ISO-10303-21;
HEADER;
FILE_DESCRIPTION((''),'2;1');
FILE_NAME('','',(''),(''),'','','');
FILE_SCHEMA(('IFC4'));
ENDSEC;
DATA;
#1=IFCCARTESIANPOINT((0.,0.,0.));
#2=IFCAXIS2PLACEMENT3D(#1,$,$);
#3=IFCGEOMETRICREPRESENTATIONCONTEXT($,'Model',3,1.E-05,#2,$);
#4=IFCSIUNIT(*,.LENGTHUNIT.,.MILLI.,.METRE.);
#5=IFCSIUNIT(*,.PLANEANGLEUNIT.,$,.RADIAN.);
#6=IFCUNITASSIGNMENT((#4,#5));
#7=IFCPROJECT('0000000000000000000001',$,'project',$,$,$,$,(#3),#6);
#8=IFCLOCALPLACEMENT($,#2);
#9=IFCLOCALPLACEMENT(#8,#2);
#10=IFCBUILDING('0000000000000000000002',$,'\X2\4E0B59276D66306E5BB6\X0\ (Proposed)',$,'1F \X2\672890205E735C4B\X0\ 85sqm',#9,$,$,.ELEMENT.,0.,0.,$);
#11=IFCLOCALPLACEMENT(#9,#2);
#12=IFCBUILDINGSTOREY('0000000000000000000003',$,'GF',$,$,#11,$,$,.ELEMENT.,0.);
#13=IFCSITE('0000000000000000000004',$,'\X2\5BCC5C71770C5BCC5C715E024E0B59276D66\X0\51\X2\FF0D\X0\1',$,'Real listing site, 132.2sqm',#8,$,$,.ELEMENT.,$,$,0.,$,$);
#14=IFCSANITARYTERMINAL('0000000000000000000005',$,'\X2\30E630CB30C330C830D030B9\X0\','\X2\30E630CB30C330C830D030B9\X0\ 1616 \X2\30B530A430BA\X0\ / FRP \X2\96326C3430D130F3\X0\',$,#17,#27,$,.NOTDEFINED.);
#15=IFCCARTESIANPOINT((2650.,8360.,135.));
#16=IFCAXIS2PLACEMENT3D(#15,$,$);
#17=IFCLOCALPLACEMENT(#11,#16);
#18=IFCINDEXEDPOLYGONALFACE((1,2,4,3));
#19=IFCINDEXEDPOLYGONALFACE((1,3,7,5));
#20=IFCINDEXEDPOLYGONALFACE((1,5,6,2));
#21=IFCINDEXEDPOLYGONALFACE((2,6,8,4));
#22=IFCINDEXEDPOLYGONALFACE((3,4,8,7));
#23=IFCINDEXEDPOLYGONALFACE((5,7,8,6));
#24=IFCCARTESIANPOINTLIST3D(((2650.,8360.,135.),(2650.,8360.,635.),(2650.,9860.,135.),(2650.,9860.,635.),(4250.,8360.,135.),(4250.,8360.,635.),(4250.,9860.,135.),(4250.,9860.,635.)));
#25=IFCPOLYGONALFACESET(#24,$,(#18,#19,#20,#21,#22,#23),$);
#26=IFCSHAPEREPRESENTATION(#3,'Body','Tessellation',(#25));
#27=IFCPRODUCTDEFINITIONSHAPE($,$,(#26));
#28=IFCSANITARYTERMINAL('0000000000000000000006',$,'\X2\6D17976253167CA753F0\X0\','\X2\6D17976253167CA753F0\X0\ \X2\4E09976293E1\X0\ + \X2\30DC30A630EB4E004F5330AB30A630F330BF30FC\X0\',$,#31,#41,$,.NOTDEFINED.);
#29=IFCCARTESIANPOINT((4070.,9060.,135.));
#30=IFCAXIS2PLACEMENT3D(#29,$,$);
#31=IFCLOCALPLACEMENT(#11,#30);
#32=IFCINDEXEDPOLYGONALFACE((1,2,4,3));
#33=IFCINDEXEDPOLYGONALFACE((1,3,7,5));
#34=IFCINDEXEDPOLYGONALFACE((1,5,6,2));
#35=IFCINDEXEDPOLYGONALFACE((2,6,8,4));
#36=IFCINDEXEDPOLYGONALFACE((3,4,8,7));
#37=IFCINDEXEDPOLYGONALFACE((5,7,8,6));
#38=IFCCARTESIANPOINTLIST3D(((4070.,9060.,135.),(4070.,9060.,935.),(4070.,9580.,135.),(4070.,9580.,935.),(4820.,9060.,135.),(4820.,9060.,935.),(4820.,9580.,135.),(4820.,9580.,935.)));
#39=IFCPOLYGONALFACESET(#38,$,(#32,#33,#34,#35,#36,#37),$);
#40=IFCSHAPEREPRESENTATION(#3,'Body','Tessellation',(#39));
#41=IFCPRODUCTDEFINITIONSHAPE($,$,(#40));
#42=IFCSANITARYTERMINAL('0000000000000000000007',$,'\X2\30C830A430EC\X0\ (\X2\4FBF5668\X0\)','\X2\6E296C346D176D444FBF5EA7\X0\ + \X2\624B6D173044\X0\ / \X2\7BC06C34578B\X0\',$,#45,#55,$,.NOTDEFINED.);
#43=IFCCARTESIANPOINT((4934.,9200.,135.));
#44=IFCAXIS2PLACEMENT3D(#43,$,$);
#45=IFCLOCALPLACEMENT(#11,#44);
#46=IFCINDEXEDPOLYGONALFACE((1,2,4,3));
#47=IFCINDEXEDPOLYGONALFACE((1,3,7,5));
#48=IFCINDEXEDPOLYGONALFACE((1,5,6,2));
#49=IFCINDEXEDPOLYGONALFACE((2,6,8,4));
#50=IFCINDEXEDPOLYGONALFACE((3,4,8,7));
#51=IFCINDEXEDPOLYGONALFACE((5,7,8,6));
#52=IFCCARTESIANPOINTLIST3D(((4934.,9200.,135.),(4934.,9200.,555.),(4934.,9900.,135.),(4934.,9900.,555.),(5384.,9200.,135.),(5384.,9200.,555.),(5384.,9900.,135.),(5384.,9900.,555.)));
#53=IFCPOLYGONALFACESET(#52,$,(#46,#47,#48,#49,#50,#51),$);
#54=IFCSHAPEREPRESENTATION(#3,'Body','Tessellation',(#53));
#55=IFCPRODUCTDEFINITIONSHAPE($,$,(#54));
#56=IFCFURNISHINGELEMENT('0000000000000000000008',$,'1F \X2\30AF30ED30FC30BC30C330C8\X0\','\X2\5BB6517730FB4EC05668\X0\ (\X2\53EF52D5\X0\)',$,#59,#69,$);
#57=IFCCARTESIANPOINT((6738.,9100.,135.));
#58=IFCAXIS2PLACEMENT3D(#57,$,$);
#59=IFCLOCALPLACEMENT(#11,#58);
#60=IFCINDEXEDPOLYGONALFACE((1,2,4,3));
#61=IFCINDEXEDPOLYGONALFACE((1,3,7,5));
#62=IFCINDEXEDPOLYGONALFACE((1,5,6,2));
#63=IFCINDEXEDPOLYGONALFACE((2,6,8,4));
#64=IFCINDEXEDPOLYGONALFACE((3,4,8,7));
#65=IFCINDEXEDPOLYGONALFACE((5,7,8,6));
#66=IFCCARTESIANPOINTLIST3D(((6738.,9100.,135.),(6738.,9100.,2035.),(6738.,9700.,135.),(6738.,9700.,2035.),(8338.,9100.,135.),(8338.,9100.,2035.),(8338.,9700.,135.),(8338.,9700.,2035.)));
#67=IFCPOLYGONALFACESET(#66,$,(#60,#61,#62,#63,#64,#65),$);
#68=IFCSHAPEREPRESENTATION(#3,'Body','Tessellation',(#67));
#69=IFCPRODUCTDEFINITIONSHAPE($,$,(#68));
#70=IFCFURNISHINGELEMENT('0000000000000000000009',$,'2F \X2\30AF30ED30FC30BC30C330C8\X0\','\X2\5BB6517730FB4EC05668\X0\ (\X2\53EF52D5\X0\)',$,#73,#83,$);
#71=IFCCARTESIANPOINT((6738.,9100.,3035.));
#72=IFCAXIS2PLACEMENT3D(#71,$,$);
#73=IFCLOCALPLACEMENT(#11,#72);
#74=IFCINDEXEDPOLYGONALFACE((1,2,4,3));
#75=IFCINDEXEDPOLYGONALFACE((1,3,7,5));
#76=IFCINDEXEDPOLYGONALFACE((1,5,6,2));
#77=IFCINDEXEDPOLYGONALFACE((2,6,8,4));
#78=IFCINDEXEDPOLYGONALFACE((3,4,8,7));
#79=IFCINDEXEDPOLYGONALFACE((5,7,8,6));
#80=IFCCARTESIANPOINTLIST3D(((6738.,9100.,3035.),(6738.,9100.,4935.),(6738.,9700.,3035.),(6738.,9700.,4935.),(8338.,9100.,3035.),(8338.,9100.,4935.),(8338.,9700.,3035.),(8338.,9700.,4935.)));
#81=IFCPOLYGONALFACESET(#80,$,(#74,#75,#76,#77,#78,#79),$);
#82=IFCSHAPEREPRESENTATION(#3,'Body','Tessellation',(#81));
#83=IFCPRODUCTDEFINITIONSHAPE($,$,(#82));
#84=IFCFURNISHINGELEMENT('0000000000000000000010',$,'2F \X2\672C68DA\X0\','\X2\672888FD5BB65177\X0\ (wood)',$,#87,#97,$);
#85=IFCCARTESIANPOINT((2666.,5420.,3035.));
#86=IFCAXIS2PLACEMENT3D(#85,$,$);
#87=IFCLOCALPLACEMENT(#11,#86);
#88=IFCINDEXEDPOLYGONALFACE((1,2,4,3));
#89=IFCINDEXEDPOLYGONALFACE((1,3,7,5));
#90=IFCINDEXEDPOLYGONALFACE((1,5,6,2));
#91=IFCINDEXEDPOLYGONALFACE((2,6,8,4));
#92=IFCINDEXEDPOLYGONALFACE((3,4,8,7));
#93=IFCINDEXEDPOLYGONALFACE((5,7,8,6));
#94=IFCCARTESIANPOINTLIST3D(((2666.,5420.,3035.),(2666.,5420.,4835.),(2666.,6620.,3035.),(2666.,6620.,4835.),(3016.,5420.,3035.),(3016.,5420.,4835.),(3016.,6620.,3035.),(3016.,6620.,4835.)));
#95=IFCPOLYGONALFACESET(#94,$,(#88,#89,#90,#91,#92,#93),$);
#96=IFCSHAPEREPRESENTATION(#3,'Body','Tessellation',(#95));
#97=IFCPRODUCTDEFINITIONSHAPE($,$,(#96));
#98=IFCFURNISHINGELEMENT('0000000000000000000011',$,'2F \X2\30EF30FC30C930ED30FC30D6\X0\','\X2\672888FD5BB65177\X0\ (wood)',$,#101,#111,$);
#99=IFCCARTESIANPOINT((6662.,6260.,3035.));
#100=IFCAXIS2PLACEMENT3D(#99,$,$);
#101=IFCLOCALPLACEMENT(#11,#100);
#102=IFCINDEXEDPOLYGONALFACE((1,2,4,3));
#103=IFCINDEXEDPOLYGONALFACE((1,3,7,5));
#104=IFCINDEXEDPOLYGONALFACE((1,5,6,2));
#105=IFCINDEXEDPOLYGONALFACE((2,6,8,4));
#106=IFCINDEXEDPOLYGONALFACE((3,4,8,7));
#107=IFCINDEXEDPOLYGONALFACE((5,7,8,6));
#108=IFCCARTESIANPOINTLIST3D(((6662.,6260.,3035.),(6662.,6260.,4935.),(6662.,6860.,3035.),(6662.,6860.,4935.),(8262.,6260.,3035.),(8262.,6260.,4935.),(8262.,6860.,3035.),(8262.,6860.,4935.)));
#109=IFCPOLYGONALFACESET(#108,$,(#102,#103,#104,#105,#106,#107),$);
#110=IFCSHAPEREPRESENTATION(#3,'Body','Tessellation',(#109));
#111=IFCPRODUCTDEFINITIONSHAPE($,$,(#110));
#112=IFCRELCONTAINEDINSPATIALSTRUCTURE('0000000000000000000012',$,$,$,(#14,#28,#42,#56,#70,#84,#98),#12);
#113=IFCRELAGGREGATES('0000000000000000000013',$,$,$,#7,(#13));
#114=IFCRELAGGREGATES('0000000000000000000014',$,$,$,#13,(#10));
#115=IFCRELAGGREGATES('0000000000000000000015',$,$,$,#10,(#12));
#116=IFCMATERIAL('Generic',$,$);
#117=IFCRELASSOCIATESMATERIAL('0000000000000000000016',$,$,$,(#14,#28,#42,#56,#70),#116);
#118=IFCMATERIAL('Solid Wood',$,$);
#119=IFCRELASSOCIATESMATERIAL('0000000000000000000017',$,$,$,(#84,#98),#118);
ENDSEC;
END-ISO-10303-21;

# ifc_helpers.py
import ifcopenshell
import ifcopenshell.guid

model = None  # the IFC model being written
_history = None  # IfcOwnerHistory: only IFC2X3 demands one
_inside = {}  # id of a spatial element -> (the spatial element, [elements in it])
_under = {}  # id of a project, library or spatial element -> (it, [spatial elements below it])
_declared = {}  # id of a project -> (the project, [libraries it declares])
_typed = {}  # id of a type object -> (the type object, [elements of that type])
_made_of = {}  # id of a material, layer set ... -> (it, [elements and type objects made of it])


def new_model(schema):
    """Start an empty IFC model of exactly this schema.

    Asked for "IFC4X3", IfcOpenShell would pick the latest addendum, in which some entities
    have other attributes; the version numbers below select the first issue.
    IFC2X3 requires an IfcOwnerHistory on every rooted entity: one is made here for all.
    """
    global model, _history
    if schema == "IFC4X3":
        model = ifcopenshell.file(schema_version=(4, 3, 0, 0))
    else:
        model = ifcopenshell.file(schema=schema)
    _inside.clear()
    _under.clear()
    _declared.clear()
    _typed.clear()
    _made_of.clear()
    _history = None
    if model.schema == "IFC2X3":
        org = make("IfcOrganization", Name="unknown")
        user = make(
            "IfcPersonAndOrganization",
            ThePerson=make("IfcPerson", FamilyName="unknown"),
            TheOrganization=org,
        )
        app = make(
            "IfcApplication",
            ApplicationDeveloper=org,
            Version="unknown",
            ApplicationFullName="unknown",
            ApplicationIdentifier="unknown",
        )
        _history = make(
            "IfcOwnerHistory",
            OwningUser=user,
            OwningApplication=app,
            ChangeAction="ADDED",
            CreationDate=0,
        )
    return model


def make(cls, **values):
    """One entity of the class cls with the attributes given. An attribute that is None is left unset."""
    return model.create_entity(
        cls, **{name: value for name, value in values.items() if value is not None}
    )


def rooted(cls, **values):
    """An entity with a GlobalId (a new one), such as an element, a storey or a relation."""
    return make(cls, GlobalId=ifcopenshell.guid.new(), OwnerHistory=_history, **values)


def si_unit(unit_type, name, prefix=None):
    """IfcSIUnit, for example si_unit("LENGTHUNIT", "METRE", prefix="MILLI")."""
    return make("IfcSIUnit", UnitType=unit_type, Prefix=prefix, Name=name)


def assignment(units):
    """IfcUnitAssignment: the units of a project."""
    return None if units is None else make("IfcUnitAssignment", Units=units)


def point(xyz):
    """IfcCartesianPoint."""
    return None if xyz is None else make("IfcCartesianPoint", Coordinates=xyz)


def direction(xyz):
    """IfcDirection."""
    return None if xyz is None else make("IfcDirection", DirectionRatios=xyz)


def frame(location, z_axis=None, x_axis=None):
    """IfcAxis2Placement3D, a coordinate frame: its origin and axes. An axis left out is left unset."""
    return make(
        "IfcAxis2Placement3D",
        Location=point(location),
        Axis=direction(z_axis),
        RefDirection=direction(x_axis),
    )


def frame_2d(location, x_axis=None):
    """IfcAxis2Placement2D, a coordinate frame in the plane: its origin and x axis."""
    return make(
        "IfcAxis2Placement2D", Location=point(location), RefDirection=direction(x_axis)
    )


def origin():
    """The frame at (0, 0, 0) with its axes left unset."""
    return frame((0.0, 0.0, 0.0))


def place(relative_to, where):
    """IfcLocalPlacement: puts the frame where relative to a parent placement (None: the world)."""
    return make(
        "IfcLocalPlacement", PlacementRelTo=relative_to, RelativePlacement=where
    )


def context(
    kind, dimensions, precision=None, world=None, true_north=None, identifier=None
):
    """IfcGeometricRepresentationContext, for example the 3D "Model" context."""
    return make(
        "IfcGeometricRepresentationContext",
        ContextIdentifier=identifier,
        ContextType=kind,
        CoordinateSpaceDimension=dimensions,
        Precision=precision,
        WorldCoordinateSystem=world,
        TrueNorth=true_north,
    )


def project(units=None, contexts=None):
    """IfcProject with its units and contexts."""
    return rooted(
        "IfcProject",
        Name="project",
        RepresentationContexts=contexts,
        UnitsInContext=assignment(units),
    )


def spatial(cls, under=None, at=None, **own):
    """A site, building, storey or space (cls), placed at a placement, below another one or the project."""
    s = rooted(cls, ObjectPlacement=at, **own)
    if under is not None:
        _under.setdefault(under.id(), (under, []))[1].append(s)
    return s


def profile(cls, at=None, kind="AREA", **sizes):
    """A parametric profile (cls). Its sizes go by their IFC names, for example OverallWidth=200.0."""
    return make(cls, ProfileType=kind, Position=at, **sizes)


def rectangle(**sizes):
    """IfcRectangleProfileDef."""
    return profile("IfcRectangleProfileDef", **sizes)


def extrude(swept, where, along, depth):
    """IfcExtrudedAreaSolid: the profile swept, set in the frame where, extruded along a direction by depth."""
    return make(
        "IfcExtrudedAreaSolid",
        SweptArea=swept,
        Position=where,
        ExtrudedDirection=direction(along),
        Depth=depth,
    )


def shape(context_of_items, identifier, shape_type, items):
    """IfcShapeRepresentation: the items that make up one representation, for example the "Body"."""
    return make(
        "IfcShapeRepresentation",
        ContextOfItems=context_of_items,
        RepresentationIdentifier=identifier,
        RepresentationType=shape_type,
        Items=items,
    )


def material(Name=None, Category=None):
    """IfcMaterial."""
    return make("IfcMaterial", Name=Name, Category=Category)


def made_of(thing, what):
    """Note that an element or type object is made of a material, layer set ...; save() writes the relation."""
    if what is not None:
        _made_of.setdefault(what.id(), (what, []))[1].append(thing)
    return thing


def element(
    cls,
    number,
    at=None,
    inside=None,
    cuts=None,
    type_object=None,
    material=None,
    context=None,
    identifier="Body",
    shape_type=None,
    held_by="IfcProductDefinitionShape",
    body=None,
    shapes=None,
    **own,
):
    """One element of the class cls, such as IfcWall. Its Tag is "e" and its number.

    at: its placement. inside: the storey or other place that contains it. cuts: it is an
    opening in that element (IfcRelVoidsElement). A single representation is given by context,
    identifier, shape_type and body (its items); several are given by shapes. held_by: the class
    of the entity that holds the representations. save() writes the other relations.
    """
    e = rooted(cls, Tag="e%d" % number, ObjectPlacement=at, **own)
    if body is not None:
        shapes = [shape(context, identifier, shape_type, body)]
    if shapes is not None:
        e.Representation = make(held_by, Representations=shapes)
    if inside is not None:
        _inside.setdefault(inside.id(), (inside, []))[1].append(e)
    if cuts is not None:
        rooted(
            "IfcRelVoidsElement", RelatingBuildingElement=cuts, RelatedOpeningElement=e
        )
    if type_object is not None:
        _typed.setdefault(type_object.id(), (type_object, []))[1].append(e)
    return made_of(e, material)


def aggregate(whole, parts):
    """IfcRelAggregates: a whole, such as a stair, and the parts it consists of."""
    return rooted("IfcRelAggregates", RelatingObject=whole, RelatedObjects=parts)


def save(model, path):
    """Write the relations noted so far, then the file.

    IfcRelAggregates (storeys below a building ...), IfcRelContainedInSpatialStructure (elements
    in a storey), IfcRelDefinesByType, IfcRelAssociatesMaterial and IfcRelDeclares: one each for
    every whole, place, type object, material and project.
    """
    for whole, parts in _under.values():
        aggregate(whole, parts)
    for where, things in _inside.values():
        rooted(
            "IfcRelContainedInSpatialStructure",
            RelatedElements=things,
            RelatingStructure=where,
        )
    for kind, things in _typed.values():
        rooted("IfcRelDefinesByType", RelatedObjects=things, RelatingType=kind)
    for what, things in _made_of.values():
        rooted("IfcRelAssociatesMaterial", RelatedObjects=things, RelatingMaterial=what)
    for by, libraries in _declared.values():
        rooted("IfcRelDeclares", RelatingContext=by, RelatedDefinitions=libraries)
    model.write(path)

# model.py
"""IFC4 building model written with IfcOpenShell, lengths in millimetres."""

from ifc_helpers import new_model, si_unit, frame, frame_2d, origin, place, context, project, spatial, rectangle, extrude, material, element, save


model = new_model("IFC4")

# Units and contexts
model_context = context("Model", 3, precision=1e-05, world=origin())
ifc_project = project(units=[si_unit("LENGTHUNIT", "METRE", prefix="MILLI"), si_unit("PLANEANGLEUNIT", "RADIAN")], contexts=[model_context])

# Site, building, storey
site_placement = place(None, origin())
site = spatial("IfcSite", under=ifc_project, at=site_placement, Name="富山県富山市下大浦51－1", ObjectType="Real listing site, 132.2sqm", CompositionType="ELEMENT", RefElevation=0.0)
building_placement = place(site_placement, origin())
building = spatial("IfcBuilding", under=site, at=building_placement, Name="下大浦の家 (Proposed)", ObjectType="1F 木造平屋 85sqm", CompositionType="ELEMENT", ElevationOfRefHeight=0.0, ElevationOfTerrain=0.0)
storey_placement = place(building_placement, origin())
storey = spatial("IfcBuildingStorey", under=building, at=storey_placement, Name="GF", CompositionType="ELEMENT", Elevation=0.0)

# Shared definitions
ifc_material_1 = material(Name="Solid Wood")

# Shared definitions
ifc_material_2 = material(Name="Generic")

# Sanitary terminals
sanitary_terminal_1_placement = place(storey_placement, frame((2650.0, 8360.0, 135.0)))
element("IfcSanitaryTerminal", 1, at=sanitary_terminal_1_placement, inside=storey, material=ifc_material_2, Name="ユニットバス", Description="ユニットバス 1616 サイズ / FRP 防水パン", PredefinedType="NOTDEFINED", context=model_context, shape_type="SweptSolid", body=[
    extrude(rectangle(XDim=1600.0, YDim=1500.0, at=frame_2d((800.0, 750.0))), frame((2650.0, 8360.0, 135.0)), (0.0, 0.0, 1.0), 500.0),
])
sanitary_terminal_2_placement = place(storey_placement, frame((4070.0, 9060.0, 135.0)))
element("IfcSanitaryTerminal", 2, at=sanitary_terminal_2_placement, inside=storey, material=ifc_material_2, Name="洗面化粧台", Description="洗面化粧台 三面鏡 + ボウル一体カウンター", PredefinedType="NOTDEFINED", context=model_context, shape_type="SweptSolid", body=[
    extrude(rectangle(XDim=750.0, YDim=520.0, at=frame_2d((375.0, 260.0))), frame((4070.0, 9060.0, 135.0)), (0.0, 0.0, 1.0), 800.0),
])
sanitary_terminal_3_placement = place(storey_placement, frame((4934.0, 9200.0, 135.0)))
element("IfcSanitaryTerminal", 3, at=sanitary_terminal_3_placement, inside=storey, material=ifc_material_2, Name="トイレ (便器)", Description="温水洗浄便座 + 手洗い / 節水型", PredefinedType="NOTDEFINED", context=model_context, shape_type="SweptSolid", body=[
    extrude(rectangle(XDim=450.0, YDim=700.0, at=frame_2d((225.0, 350.0))), frame((4934.0, 9200.0, 135.0)), (0.0, 0.0, 1.0), 420.0),
])

# Furnishing elements
furnishing_1_placement = place(storey_placement, frame((6738.0, 9100.0, 135.0)))
element("IfcFurnishingElement", 4, at=furnishing_1_placement, inside=storey, material=ifc_material_2, Name="1F クローゼット", Description="家具・什器 (可動)", context=model_context, shape_type="SweptSolid", body=[
    extrude(rectangle(XDim=1600.0, YDim=600.0, at=frame_2d((800.0, 300.0))), frame((6738.0, 9100.0, 135.0)), (0.0, 0.0, 1.0), 1900.0),
])
furnishing_2_placement = place(storey_placement, frame((6738.0, 9100.0, 3035.0)))
element("IfcFurnishingElement", 5, at=furnishing_2_placement, inside=storey, material=ifc_material_2, Name="2F クローゼット", Description="家具・什器 (可動)", context=model_context, shape_type="SweptSolid", body=[
    extrude(rectangle(XDim=1600.0, YDim=600.0, at=frame_2d((800.0, 300.0))), frame((6738.0, 9100.0, 3035.0)), (0.0, 0.0, 1.0), 1900.0),
])
furnishing_3_placement = place(storey_placement, frame((2666.0, 5420.0, 3035.0)))
element("IfcFurnishingElement", 6, at=furnishing_3_placement, inside=storey, material=ifc_material_1, Name="2F 本棚", Description="木製家具 (wood)", context=model_context, shape_type="SweptSolid", body=[
    extrude(rectangle(XDim=350.0, YDim=1200.0, at=frame_2d((175.0, 600.0))), frame((2666.0, 5420.0, 3035.0)), (0.0, 0.0, 1.0), 1800.0),
])
furnishing_4_placement = place(storey_placement, frame((6662.0, 6260.0, 3035.0)))
element("IfcFurnishingElement", 7, at=furnishing_4_placement, inside=storey, material=ifc_material_1, Name="2F ワードローブ", Description="木製家具 (wood)", context=model_context, shape_type="SweptSolid", body=[
    extrude(rectangle(XDim=1600.0, YDim=600.0, at=frame_2d((800.0, 300.0))), frame((6662.0, 6260.0, 3035.0)), (0.0, 0.0, 1.0), 1900.0),
])

save(model, "model.ifc")
